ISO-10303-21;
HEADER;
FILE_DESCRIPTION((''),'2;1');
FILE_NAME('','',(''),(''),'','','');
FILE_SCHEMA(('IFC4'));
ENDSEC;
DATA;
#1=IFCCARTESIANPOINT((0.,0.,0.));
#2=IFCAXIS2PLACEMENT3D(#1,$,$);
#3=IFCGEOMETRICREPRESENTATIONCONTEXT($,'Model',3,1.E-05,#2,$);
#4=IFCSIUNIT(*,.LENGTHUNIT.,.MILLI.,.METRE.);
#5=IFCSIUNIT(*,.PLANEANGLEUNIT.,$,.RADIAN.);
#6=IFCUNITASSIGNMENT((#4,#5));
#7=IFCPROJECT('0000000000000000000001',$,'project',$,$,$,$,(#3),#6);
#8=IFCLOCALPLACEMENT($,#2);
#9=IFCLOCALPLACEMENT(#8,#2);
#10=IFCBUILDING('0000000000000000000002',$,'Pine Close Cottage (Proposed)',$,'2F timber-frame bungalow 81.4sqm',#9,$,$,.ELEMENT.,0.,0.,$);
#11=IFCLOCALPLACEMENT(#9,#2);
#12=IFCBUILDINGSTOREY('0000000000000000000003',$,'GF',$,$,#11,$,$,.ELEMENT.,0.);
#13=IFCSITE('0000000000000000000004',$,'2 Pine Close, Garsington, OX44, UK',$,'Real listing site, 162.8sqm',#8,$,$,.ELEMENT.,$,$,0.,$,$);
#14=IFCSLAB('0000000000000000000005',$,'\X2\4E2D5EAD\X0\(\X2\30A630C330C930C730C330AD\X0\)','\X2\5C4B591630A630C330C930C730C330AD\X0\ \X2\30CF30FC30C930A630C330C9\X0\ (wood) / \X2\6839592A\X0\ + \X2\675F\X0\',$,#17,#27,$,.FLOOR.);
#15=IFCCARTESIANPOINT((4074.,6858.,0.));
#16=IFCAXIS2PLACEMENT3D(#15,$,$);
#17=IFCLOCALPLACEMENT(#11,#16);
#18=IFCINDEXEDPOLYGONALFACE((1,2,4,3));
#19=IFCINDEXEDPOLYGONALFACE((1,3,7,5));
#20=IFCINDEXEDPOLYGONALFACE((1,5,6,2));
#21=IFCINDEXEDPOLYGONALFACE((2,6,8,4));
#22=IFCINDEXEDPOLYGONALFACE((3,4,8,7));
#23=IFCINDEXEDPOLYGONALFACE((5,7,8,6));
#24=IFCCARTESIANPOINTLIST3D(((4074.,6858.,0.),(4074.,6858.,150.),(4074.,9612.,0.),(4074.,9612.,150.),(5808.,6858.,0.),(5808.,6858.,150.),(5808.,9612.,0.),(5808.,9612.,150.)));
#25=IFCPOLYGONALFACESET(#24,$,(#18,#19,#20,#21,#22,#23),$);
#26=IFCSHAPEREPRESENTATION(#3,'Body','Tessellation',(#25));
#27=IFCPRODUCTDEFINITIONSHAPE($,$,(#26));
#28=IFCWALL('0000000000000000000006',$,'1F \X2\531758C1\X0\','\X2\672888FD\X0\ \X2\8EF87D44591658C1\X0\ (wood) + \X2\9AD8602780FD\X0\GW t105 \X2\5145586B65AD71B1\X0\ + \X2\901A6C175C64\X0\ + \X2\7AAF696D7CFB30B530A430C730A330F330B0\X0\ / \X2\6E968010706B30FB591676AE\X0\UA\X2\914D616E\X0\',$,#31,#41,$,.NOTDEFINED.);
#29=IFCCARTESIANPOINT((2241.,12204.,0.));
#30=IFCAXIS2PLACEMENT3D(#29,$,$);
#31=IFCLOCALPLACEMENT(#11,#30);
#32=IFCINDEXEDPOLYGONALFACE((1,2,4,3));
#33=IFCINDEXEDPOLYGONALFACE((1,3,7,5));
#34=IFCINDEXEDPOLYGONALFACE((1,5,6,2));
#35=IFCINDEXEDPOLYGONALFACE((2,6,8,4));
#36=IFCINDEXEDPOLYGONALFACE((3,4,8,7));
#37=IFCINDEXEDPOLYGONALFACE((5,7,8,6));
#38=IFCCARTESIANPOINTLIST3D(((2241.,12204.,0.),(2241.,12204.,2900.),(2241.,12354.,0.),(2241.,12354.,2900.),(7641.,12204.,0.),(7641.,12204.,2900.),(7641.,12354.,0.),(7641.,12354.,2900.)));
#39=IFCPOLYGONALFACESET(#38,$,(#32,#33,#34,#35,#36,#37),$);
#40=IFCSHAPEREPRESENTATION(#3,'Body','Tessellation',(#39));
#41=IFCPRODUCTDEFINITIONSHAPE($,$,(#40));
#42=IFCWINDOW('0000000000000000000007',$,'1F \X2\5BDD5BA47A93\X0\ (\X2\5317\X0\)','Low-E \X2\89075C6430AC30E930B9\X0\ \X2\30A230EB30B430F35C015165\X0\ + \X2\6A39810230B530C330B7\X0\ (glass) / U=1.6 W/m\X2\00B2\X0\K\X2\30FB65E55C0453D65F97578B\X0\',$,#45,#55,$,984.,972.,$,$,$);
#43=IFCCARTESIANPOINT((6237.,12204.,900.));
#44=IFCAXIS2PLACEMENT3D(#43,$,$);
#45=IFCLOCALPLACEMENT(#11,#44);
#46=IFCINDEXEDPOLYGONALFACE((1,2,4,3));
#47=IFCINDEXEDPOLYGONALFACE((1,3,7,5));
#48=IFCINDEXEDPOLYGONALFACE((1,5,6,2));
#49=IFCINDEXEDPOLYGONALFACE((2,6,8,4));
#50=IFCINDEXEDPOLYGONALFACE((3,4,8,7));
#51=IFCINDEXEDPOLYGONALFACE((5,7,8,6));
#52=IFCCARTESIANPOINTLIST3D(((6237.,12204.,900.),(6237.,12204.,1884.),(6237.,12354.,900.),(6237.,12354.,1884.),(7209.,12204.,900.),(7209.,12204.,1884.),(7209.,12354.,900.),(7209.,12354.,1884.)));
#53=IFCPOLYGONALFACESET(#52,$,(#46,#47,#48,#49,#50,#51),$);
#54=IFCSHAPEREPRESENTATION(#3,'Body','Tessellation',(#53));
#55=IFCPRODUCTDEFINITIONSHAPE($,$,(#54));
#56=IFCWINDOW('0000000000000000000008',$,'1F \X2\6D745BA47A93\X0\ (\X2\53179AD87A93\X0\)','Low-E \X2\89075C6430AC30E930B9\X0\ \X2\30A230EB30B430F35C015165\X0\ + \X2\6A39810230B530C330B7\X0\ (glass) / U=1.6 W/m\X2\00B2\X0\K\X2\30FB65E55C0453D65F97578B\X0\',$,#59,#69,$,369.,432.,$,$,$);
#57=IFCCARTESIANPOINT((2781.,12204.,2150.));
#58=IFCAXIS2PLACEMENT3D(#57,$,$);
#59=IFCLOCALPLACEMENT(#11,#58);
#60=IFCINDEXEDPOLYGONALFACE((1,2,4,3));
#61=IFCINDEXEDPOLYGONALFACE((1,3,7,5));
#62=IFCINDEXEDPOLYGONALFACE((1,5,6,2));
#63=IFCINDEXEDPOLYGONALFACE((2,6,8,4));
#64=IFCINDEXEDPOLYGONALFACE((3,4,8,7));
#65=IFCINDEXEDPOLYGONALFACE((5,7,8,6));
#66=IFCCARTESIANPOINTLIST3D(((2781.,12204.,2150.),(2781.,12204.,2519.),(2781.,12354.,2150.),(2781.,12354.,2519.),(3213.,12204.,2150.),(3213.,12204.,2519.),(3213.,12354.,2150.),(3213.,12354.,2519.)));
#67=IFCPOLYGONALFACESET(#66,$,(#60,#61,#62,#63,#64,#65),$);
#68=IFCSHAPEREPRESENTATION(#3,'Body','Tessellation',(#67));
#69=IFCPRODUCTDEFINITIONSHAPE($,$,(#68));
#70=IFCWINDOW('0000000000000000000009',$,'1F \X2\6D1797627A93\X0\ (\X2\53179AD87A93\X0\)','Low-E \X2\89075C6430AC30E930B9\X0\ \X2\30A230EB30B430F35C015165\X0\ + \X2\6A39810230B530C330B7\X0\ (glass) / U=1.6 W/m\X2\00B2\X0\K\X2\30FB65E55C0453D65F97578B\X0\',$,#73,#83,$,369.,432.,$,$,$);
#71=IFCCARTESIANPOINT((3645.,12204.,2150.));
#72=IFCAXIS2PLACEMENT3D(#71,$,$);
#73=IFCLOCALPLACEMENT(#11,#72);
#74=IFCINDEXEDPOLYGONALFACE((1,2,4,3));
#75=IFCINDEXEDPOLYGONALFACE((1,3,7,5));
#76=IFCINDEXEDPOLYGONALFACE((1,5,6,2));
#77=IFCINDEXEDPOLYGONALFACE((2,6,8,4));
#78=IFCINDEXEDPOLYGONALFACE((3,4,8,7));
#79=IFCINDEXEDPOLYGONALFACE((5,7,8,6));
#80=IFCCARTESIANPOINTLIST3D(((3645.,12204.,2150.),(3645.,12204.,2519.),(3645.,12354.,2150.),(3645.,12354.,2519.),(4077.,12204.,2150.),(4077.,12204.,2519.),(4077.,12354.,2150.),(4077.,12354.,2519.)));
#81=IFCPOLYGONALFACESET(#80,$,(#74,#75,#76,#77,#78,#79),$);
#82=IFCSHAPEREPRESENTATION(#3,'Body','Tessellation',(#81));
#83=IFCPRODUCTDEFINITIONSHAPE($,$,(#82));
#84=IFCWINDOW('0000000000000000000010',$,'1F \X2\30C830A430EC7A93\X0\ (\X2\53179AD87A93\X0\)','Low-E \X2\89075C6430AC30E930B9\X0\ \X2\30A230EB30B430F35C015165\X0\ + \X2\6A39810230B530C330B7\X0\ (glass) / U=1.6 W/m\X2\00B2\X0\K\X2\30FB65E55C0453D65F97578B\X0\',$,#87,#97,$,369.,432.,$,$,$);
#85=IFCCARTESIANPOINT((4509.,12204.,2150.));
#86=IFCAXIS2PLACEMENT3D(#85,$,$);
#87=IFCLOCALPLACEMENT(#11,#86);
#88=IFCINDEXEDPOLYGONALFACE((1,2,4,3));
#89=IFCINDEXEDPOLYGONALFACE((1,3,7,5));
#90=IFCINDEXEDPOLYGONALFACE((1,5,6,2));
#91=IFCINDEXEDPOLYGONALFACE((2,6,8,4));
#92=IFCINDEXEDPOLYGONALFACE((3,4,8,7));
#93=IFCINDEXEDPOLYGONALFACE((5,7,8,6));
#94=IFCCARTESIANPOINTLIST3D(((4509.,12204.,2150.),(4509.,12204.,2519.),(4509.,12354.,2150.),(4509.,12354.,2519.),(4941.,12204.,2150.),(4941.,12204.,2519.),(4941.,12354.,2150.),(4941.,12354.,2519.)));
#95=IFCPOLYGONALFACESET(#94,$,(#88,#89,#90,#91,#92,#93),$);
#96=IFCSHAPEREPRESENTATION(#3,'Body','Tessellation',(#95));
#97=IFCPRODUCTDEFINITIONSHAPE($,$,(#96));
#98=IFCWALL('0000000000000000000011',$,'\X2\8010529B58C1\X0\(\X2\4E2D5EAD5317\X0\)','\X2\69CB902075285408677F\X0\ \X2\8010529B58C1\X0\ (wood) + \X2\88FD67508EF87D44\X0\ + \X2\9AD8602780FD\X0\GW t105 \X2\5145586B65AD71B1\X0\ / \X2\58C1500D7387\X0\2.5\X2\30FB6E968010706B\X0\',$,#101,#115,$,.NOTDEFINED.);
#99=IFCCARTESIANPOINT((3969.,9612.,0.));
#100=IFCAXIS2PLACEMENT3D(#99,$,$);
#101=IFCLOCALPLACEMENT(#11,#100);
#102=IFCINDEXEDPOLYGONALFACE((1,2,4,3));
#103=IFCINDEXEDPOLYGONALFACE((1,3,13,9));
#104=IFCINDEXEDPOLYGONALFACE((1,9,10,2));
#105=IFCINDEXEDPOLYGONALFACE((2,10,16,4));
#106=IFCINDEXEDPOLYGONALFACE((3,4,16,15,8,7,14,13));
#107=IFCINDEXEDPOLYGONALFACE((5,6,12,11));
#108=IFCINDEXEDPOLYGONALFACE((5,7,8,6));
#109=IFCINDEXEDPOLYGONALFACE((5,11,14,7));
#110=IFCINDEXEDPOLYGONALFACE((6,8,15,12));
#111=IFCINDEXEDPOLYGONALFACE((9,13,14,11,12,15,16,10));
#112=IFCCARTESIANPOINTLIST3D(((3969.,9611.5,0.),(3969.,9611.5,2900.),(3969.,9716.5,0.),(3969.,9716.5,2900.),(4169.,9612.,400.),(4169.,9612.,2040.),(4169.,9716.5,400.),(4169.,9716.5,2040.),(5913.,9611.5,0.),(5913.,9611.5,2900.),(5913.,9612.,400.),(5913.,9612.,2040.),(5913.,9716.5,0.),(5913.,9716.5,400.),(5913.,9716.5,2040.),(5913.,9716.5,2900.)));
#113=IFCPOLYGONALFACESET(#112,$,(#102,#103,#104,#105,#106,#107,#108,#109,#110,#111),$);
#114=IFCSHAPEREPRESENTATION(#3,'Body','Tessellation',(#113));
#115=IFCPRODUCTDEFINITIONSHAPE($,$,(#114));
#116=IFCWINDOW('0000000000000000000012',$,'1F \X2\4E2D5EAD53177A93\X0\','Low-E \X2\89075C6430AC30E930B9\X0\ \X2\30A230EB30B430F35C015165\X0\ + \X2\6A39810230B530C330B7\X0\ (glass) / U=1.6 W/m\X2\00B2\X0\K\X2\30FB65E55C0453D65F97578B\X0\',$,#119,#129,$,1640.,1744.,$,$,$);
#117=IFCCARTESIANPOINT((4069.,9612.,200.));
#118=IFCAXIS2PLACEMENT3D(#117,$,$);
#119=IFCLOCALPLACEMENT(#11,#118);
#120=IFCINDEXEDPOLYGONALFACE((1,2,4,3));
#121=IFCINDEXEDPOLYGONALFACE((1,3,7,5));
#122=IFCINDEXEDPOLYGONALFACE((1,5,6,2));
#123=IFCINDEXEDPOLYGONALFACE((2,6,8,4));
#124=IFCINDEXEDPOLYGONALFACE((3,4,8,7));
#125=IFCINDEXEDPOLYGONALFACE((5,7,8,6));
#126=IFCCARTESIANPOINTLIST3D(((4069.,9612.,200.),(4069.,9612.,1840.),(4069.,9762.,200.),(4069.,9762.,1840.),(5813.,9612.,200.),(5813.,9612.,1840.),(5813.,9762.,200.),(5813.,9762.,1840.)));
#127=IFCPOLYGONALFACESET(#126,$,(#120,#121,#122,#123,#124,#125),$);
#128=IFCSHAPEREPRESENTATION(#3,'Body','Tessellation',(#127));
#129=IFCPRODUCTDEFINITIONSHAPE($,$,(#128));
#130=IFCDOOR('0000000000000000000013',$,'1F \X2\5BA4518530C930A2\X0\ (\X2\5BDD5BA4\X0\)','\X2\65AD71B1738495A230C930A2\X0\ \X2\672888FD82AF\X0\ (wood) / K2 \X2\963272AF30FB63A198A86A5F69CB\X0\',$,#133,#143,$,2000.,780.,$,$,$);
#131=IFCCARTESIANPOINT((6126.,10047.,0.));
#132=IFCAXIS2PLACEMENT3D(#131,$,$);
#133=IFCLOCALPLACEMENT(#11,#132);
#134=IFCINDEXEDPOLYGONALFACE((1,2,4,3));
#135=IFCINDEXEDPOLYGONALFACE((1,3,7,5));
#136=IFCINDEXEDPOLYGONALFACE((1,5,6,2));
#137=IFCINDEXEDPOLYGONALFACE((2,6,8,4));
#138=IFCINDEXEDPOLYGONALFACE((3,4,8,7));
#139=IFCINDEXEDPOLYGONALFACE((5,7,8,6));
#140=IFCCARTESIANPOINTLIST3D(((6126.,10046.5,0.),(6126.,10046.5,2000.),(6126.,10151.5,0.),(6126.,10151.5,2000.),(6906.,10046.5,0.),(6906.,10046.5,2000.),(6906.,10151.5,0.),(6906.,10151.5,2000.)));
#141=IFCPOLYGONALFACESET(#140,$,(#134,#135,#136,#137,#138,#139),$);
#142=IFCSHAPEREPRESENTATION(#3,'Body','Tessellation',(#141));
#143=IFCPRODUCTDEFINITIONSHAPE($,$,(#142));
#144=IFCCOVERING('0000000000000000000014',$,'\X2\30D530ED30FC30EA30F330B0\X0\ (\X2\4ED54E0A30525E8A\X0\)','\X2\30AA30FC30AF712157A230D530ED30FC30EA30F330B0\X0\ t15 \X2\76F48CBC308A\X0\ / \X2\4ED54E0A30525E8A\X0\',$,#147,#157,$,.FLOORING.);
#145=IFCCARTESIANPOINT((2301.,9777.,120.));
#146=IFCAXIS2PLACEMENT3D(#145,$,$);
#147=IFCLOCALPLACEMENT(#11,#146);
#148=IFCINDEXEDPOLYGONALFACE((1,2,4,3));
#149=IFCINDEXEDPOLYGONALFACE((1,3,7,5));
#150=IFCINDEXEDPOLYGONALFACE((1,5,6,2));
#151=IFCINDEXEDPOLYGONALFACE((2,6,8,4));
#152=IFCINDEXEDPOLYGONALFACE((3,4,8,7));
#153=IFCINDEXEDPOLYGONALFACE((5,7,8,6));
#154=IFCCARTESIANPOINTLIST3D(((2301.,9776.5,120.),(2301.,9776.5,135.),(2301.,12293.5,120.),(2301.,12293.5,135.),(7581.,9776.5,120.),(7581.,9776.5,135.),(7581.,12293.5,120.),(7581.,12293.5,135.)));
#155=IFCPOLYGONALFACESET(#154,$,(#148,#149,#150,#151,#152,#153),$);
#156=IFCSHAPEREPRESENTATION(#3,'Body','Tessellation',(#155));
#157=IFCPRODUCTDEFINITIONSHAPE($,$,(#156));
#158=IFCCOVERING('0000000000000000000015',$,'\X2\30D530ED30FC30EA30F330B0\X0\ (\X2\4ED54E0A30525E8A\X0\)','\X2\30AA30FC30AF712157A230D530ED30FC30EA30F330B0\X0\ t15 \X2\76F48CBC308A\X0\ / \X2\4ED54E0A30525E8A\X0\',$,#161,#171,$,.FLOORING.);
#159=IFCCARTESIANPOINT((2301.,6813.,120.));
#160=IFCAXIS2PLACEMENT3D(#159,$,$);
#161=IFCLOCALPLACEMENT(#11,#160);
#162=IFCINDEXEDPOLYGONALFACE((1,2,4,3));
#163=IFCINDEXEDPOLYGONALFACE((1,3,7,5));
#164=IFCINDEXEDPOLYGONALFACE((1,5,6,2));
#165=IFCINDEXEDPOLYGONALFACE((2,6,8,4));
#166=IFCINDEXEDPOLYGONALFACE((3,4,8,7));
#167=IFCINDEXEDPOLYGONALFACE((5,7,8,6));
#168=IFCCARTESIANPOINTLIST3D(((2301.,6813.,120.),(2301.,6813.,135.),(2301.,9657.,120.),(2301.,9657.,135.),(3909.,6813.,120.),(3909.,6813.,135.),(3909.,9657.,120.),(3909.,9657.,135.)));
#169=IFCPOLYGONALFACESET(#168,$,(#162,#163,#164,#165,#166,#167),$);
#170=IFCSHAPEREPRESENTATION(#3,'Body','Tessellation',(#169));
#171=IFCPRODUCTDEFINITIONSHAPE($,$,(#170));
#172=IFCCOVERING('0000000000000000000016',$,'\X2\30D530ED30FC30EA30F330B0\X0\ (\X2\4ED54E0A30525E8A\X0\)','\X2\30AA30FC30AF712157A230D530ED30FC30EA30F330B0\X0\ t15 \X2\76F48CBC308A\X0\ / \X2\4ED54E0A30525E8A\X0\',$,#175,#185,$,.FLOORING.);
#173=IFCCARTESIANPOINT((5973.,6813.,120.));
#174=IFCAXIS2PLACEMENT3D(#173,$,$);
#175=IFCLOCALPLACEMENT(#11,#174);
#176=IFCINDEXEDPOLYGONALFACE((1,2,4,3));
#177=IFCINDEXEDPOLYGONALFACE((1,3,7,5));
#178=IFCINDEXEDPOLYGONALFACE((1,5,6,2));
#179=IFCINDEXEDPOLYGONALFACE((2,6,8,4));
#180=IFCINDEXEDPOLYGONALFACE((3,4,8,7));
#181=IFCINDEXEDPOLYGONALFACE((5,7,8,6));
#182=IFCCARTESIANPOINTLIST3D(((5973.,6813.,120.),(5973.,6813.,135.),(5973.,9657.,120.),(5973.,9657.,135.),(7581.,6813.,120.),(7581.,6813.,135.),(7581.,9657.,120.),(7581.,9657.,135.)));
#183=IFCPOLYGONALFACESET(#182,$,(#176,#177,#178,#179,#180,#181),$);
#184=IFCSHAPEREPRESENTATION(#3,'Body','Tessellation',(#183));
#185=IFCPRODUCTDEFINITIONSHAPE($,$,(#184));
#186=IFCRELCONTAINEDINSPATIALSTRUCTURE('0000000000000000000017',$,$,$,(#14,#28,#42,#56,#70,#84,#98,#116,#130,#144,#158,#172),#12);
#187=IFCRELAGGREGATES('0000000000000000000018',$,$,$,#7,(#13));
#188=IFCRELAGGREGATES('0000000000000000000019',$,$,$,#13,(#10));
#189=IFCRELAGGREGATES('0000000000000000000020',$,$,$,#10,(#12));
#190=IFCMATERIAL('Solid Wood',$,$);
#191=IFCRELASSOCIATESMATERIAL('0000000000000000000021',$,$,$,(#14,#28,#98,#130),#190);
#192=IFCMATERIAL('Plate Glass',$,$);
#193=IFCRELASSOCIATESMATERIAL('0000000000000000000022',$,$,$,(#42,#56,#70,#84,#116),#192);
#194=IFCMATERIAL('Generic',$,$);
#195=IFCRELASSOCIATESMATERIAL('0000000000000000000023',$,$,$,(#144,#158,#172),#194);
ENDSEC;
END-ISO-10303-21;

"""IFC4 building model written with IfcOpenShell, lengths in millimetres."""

from ifc_helpers import new_model, si_unit, frame, frame_2d, origin, place, context, project, spatial, rectangle, extrude, material, element, fill, save


model = new_model("IFC4")

# Units and contexts
model_context = context("Model", 3, precision=1e-05, world=origin())
ifc_project = project(units=[si_unit("LENGTHUNIT", "METRE", prefix="MILLI"), si_unit("PLANEANGLEUNIT", "RADIAN")], contexts=[model_context])

# Site, building, storey
site_placement = place(None, origin())
site = spatial("IfcSite", under=ifc_project, at=site_placement, Name="2 Pine Close, Garsington, OX44, UK", ObjectType="Real listing site, 162.8sqm", CompositionType="ELEMENT", RefElevation=0.0)
building_placement = place(site_placement, origin())
building = spatial("IfcBuilding", under=site, at=building_placement, Name="Pine Close Cottage (Proposed)", ObjectType="2F timber-frame bungalow 81.4sqm", CompositionType="ELEMENT", ElevationOfRefHeight=0.0, ElevationOfTerrain=0.0)
storey_placement = place(building_placement, origin())
storey = spatial("IfcBuildingStorey", under=building, at=storey_placement, Name="GF", CompositionType="ELEMENT", Elevation=0.0)

# Slab
ifc_material_1 = material(Name="Solid Wood")
slab_1_placement = place(storey_placement, frame((4074.0, 6858.0, 0.0)))
element("IfcSlab", 1, at=slab_1_placement, inside=storey, material=ifc_material_1, Name="中庭(ウッドデッキ)", Description="屋外ウッドデッキ ハードウッド (wood) / 根太 + 束", PredefinedType="FLOOR", context=model_context, shape_type="SweptSolid", body=[
    extrude(rectangle(XDim=1734.0, YDim=2754.0, at=frame_2d((867.0, 1377.0))), frame((4074.0, 6858.0, 0.0)), (0.0, 0.0, 1.0), 150.0),
])

# Wall, openings, windows
wall_1_placement = place(storey_placement, frame((2241.0, 12204.0, 0.0)))
wall_1 = element("IfcWall", 2, at=wall_1_placement, inside=storey, material=ifc_material_1, Name="1F 北壁", Description="木製 軸組外壁 (wood) + 高性能GW t105 充填断熱 + 通気層 + 窯業系サイディング / 準耐火・外皮UA配慮", PredefinedType="NOTDEFINED", context=model_context, shape_type="SweptSolid", body=[
    extrude(rectangle(XDim=5400.0, YDim=150.0, at=frame_2d((2700.0, 75.0))), frame((2241.0, 12204.0, 0.0)), (0.0, 0.0, 1.0), 2900.0),
])
opening_1_placement = place(storey_placement, frame((6237.0, 12204.0, 900.0)))
opening_1 = element("IfcOpeningElement", 3, at=opening_1_placement, cuts=wall_1, PredefinedType="NOTDEFINED", context=model_context, shape_type="SweptSolid", body=[
    extrude(rectangle(XDim=972.0, YDim=150.0, at=frame_2d((486.0, 75.0))), frame((6237.0, 12204.0, 900.0)), (0.0, 0.0, 1.0), 984.0),
])
opening_2_placement = place(storey_placement, frame((2781.0, 12204.0, 2150.0)))
opening_2 = element("IfcOpeningElement", 4, at=opening_2_placement, cuts=wall_1, PredefinedType="NOTDEFINED", context=model_context, shape_type="SweptSolid", body=[
    extrude(rectangle(XDim=432.0, YDim=150.0, at=frame_2d((216.0, 75.0))), frame((2781.0, 12204.0, 2150.0)), (0.0, 0.0, 1.0), 369.0),
])
opening_3_placement = place(storey_placement, frame((3645.0, 12204.0, 2150.0)))
opening_3 = element("IfcOpeningElement", 5, at=opening_3_placement, cuts=wall_1, PredefinedType="NOTDEFINED", context=model_context, shape_type="SweptSolid", body=[
    extrude(rectangle(XDim=432.0, YDim=150.0, at=frame_2d((216.0, 75.0))), frame((3645.0, 12204.0, 2150.0)), (0.0, 0.0, 1.0), 369.0),
])
opening_4_placement = place(storey_placement, frame((4509.0, 12204.0, 2150.0)))
opening_4 = element("IfcOpeningElement", 6, at=opening_4_placement, cuts=wall_1, PredefinedType="NOTDEFINED", context=model_context, shape_type="SweptSolid", body=[
    extrude(rectangle(XDim=432.0, YDim=150.0, at=frame_2d((216.0, 75.0))), frame((4509.0, 12204.0, 2150.0)), (0.0, 0.0, 1.0), 369.0),
])
ifc_material_2 = material(Name="Plate Glass")
window_1_placement = place(storey_placement, frame((6237.0, 12204.0, 900.0)))
window_1 = element("IfcWindow", 7, at=window_1_placement, inside=storey, material=ifc_material_2, Name="1F 寝室窓 (北)", Description="Low-E 複層ガラス アルゴン封入 + 樹脂サッシ (glass) / U=1.6 W/m²K・日射取得型", OverallHeight=984.0, OverallWidth=972.0, context=model_context, shape_type="SweptSolid", body=[
    extrude(rectangle(XDim=972.0, YDim=150.0, at=frame_2d((486.0, 75.0))), frame((6237.0, 12204.0, 900.0)), (0.0, 0.0, 1.0), 984.0),
])
fill(opening_1, window_1)
window_2_placement = place(storey_placement, frame((2781.0, 12204.0, 2150.0)))
window_2 = element("IfcWindow", 8, at=window_2_placement, inside=storey, material=ifc_material_2, Name="1F 浴室窓 (北高窓)", Description="Low-E 複層ガラス アルゴン封入 + 樹脂サッシ (glass) / U=1.6 W/m²K・日射取得型", OverallHeight=369.0, OverallWidth=432.0, context=model_context, shape_type="SweptSolid", body=[
    extrude(rectangle(XDim=432.0, YDim=150.0, at=frame_2d((216.0, 75.0))), frame((2781.0, 12204.0, 2150.0)), (0.0, 0.0, 1.0), 369.0),
])
fill(opening_2, window_2)
window_3_placement = place(storey_placement, frame((3645.0, 12204.0, 2150.0)))
window_3 = element("IfcWindow", 9, at=window_3_placement, inside=storey, material=ifc_material_2, Name="1F 洗面窓 (北高窓)", Description="Low-E 複層ガラス アルゴン封入 + 樹脂サッシ (glass) / U=1.6 W/m²K・日射取得型", OverallHeight=369.0, OverallWidth=432.0, context=model_context, shape_type="SweptSolid", body=[
    extrude(rectangle(XDim=432.0, YDim=150.0, at=frame_2d((216.0, 75.0))), frame((3645.0, 12204.0, 2150.0)), (0.0, 0.0, 1.0), 369.0),
])
fill(opening_3, window_3)
window_4_placement = place(storey_placement, frame((4509.0, 12204.0, 2150.0)))
window_4 = element("IfcWindow", 10, at=window_4_placement, inside=storey, material=ifc_material_2, Name="1F トイレ窓 (北高窓)", Description="Low-E 複層ガラス アルゴン封入 + 樹脂サッシ (glass) / U=1.6 W/m²K・日射取得型", OverallHeight=369.0, OverallWidth=432.0, context=model_context, shape_type="SweptSolid", body=[
    extrude(rectangle(XDim=432.0, YDim=150.0, at=frame_2d((216.0, 75.0))), frame((4509.0, 12204.0, 2150.0)), (0.0, 0.0, 1.0), 369.0),
])
fill(opening_4, window_4)

# Wall, opening, window
wall_2_placement = place(storey_placement, frame((3969.0, 9612.0, 0.0)))
wall_2 = element("IfcWall", 11, at=wall_2_placement, inside=storey, material=ifc_material_1, Name="耐力壁(中庭北)", Description="構造用合板 耐力壁 (wood) + 製材軸組 + 高性能GW t105 充填断熱 / 壁倍率2.5・準耐火", PredefinedType="NOTDEFINED", context=model_context, shape_type="SweptSolid", body=[
    extrude(rectangle(XDim=1944.0, YDim=105.0, at=frame_2d((972.0, 52.0))), frame((3969.0, 9612.0, 0.0)), (0.0, 0.0, 1.0), 2900.0),
])
opening_5_placement = place(storey_placement, frame((4069.0, 9612.0, 200.0)))
opening_5 = element("IfcOpeningElement", 12, at=opening_5_placement, cuts=wall_2, PredefinedType="NOTDEFINED", context=model_context, shape_type="SweptSolid", body=[
    extrude(rectangle(XDim=1744.0, YDim=150.0, at=frame_2d((872.0, 75.0))), frame((4069.0, 9612.0, 200.0)), (0.0, 0.0, 1.0), 1640.0),
])
window_5_placement = place(storey_placement, frame((4069.0, 9612.0, 200.0)))
window_5 = element("IfcWindow", 13, at=window_5_placement, inside=storey, material=ifc_material_2, Name="1F 中庭北窓", Description="Low-E 複層ガラス アルゴン封入 + 樹脂サッシ (glass) / U=1.6 W/m²K・日射取得型", OverallHeight=1640.0, OverallWidth=1744.0, context=model_context, shape_type="SweptSolid", body=[
    extrude(rectangle(XDim=1744.0, YDim=150.0, at=frame_2d((872.0, 75.0))), frame((4069.0, 9612.0, 200.0)), (0.0, 0.0, 1.0), 1640.0),
])
fill(opening_5, window_5)

# Door
door_1_placement = place(storey_placement, frame((6126.0, 10047.0, 0.0)))
element("IfcDoor", 14, at=door_1_placement, inside=storey, material=ifc_material_1, Name="1F 室内ドア (寝室)", Description="断熱玄関ドア 木製芯 (wood) / K2 防犯・採風機構", OverallHeight=2000.0, OverallWidth=780.0, context=model_context, shape_type="SweptSolid", body=[
    extrude(rectangle(XDim=780.0, YDim=105.0, at=frame_2d((390.0, 52.0))), frame((6126.0, 10047.0, 0.0)), (0.0, 0.0, 1.0), 2000.0),
])

# Coverings
ifc_material_3 = material(Name="Generic")
covering_1_placement = place(storey_placement, frame((2301.0, 9777.0, 120.0)))
element("IfcCovering", 15, at=covering_1_placement, inside=storey, material=ifc_material_3, Name="フローリング (仕上げ床)", Description="オーク無垢フローリング t15 直貼り / 仕上げ床", PredefinedType="FLOORING", context=model_context, shape_type="SweptSolid", body=[
    extrude(rectangle(XDim=5280.0, YDim=2517.0, at=frame_2d((2640.0, 1258.0))), frame((2301.0, 9777.0, 120.0)), (0.0, 0.0, 1.0), 15.0),
])
covering_2_placement = place(storey_placement, frame((2301.0, 6813.0, 120.0)))
element("IfcCovering", 16, at=covering_2_placement, inside=storey, material=ifc_material_3, Name="フローリング (仕上げ床)", Description="オーク無垢フローリング t15 直貼り / 仕上げ床", PredefinedType="FLOORING", context=model_context, shape_type="SweptSolid", body=[
    extrude(rectangle(XDim=1608.0, YDim=2844.0, at=frame_2d((804.0, 1422.0))), frame((2301.0, 6813.0, 120.0)), (0.0, 0.0, 1.0), 15.0),
])
covering_3_placement = place(storey_placement, frame((5973.0, 6813.0, 120.0)))
element("IfcCovering", 17, at=covering_3_placement, inside=storey, material=ifc_material_3, Name="フローリング (仕上げ床)", Description="オーク無垢フローリング t15 直貼り / 仕上げ床", PredefinedType="FLOORING", context=model_context, shape_type="SweptSolid", body=[
    extrude(rectangle(XDim=1608.0, YDim=2844.0, at=frame_2d((804.0, 1422.0))), frame((5973.0, 6813.0, 120.0)), (0.0, 0.0, 1.0), 15.0),
])

save(model, "model.ifc")
